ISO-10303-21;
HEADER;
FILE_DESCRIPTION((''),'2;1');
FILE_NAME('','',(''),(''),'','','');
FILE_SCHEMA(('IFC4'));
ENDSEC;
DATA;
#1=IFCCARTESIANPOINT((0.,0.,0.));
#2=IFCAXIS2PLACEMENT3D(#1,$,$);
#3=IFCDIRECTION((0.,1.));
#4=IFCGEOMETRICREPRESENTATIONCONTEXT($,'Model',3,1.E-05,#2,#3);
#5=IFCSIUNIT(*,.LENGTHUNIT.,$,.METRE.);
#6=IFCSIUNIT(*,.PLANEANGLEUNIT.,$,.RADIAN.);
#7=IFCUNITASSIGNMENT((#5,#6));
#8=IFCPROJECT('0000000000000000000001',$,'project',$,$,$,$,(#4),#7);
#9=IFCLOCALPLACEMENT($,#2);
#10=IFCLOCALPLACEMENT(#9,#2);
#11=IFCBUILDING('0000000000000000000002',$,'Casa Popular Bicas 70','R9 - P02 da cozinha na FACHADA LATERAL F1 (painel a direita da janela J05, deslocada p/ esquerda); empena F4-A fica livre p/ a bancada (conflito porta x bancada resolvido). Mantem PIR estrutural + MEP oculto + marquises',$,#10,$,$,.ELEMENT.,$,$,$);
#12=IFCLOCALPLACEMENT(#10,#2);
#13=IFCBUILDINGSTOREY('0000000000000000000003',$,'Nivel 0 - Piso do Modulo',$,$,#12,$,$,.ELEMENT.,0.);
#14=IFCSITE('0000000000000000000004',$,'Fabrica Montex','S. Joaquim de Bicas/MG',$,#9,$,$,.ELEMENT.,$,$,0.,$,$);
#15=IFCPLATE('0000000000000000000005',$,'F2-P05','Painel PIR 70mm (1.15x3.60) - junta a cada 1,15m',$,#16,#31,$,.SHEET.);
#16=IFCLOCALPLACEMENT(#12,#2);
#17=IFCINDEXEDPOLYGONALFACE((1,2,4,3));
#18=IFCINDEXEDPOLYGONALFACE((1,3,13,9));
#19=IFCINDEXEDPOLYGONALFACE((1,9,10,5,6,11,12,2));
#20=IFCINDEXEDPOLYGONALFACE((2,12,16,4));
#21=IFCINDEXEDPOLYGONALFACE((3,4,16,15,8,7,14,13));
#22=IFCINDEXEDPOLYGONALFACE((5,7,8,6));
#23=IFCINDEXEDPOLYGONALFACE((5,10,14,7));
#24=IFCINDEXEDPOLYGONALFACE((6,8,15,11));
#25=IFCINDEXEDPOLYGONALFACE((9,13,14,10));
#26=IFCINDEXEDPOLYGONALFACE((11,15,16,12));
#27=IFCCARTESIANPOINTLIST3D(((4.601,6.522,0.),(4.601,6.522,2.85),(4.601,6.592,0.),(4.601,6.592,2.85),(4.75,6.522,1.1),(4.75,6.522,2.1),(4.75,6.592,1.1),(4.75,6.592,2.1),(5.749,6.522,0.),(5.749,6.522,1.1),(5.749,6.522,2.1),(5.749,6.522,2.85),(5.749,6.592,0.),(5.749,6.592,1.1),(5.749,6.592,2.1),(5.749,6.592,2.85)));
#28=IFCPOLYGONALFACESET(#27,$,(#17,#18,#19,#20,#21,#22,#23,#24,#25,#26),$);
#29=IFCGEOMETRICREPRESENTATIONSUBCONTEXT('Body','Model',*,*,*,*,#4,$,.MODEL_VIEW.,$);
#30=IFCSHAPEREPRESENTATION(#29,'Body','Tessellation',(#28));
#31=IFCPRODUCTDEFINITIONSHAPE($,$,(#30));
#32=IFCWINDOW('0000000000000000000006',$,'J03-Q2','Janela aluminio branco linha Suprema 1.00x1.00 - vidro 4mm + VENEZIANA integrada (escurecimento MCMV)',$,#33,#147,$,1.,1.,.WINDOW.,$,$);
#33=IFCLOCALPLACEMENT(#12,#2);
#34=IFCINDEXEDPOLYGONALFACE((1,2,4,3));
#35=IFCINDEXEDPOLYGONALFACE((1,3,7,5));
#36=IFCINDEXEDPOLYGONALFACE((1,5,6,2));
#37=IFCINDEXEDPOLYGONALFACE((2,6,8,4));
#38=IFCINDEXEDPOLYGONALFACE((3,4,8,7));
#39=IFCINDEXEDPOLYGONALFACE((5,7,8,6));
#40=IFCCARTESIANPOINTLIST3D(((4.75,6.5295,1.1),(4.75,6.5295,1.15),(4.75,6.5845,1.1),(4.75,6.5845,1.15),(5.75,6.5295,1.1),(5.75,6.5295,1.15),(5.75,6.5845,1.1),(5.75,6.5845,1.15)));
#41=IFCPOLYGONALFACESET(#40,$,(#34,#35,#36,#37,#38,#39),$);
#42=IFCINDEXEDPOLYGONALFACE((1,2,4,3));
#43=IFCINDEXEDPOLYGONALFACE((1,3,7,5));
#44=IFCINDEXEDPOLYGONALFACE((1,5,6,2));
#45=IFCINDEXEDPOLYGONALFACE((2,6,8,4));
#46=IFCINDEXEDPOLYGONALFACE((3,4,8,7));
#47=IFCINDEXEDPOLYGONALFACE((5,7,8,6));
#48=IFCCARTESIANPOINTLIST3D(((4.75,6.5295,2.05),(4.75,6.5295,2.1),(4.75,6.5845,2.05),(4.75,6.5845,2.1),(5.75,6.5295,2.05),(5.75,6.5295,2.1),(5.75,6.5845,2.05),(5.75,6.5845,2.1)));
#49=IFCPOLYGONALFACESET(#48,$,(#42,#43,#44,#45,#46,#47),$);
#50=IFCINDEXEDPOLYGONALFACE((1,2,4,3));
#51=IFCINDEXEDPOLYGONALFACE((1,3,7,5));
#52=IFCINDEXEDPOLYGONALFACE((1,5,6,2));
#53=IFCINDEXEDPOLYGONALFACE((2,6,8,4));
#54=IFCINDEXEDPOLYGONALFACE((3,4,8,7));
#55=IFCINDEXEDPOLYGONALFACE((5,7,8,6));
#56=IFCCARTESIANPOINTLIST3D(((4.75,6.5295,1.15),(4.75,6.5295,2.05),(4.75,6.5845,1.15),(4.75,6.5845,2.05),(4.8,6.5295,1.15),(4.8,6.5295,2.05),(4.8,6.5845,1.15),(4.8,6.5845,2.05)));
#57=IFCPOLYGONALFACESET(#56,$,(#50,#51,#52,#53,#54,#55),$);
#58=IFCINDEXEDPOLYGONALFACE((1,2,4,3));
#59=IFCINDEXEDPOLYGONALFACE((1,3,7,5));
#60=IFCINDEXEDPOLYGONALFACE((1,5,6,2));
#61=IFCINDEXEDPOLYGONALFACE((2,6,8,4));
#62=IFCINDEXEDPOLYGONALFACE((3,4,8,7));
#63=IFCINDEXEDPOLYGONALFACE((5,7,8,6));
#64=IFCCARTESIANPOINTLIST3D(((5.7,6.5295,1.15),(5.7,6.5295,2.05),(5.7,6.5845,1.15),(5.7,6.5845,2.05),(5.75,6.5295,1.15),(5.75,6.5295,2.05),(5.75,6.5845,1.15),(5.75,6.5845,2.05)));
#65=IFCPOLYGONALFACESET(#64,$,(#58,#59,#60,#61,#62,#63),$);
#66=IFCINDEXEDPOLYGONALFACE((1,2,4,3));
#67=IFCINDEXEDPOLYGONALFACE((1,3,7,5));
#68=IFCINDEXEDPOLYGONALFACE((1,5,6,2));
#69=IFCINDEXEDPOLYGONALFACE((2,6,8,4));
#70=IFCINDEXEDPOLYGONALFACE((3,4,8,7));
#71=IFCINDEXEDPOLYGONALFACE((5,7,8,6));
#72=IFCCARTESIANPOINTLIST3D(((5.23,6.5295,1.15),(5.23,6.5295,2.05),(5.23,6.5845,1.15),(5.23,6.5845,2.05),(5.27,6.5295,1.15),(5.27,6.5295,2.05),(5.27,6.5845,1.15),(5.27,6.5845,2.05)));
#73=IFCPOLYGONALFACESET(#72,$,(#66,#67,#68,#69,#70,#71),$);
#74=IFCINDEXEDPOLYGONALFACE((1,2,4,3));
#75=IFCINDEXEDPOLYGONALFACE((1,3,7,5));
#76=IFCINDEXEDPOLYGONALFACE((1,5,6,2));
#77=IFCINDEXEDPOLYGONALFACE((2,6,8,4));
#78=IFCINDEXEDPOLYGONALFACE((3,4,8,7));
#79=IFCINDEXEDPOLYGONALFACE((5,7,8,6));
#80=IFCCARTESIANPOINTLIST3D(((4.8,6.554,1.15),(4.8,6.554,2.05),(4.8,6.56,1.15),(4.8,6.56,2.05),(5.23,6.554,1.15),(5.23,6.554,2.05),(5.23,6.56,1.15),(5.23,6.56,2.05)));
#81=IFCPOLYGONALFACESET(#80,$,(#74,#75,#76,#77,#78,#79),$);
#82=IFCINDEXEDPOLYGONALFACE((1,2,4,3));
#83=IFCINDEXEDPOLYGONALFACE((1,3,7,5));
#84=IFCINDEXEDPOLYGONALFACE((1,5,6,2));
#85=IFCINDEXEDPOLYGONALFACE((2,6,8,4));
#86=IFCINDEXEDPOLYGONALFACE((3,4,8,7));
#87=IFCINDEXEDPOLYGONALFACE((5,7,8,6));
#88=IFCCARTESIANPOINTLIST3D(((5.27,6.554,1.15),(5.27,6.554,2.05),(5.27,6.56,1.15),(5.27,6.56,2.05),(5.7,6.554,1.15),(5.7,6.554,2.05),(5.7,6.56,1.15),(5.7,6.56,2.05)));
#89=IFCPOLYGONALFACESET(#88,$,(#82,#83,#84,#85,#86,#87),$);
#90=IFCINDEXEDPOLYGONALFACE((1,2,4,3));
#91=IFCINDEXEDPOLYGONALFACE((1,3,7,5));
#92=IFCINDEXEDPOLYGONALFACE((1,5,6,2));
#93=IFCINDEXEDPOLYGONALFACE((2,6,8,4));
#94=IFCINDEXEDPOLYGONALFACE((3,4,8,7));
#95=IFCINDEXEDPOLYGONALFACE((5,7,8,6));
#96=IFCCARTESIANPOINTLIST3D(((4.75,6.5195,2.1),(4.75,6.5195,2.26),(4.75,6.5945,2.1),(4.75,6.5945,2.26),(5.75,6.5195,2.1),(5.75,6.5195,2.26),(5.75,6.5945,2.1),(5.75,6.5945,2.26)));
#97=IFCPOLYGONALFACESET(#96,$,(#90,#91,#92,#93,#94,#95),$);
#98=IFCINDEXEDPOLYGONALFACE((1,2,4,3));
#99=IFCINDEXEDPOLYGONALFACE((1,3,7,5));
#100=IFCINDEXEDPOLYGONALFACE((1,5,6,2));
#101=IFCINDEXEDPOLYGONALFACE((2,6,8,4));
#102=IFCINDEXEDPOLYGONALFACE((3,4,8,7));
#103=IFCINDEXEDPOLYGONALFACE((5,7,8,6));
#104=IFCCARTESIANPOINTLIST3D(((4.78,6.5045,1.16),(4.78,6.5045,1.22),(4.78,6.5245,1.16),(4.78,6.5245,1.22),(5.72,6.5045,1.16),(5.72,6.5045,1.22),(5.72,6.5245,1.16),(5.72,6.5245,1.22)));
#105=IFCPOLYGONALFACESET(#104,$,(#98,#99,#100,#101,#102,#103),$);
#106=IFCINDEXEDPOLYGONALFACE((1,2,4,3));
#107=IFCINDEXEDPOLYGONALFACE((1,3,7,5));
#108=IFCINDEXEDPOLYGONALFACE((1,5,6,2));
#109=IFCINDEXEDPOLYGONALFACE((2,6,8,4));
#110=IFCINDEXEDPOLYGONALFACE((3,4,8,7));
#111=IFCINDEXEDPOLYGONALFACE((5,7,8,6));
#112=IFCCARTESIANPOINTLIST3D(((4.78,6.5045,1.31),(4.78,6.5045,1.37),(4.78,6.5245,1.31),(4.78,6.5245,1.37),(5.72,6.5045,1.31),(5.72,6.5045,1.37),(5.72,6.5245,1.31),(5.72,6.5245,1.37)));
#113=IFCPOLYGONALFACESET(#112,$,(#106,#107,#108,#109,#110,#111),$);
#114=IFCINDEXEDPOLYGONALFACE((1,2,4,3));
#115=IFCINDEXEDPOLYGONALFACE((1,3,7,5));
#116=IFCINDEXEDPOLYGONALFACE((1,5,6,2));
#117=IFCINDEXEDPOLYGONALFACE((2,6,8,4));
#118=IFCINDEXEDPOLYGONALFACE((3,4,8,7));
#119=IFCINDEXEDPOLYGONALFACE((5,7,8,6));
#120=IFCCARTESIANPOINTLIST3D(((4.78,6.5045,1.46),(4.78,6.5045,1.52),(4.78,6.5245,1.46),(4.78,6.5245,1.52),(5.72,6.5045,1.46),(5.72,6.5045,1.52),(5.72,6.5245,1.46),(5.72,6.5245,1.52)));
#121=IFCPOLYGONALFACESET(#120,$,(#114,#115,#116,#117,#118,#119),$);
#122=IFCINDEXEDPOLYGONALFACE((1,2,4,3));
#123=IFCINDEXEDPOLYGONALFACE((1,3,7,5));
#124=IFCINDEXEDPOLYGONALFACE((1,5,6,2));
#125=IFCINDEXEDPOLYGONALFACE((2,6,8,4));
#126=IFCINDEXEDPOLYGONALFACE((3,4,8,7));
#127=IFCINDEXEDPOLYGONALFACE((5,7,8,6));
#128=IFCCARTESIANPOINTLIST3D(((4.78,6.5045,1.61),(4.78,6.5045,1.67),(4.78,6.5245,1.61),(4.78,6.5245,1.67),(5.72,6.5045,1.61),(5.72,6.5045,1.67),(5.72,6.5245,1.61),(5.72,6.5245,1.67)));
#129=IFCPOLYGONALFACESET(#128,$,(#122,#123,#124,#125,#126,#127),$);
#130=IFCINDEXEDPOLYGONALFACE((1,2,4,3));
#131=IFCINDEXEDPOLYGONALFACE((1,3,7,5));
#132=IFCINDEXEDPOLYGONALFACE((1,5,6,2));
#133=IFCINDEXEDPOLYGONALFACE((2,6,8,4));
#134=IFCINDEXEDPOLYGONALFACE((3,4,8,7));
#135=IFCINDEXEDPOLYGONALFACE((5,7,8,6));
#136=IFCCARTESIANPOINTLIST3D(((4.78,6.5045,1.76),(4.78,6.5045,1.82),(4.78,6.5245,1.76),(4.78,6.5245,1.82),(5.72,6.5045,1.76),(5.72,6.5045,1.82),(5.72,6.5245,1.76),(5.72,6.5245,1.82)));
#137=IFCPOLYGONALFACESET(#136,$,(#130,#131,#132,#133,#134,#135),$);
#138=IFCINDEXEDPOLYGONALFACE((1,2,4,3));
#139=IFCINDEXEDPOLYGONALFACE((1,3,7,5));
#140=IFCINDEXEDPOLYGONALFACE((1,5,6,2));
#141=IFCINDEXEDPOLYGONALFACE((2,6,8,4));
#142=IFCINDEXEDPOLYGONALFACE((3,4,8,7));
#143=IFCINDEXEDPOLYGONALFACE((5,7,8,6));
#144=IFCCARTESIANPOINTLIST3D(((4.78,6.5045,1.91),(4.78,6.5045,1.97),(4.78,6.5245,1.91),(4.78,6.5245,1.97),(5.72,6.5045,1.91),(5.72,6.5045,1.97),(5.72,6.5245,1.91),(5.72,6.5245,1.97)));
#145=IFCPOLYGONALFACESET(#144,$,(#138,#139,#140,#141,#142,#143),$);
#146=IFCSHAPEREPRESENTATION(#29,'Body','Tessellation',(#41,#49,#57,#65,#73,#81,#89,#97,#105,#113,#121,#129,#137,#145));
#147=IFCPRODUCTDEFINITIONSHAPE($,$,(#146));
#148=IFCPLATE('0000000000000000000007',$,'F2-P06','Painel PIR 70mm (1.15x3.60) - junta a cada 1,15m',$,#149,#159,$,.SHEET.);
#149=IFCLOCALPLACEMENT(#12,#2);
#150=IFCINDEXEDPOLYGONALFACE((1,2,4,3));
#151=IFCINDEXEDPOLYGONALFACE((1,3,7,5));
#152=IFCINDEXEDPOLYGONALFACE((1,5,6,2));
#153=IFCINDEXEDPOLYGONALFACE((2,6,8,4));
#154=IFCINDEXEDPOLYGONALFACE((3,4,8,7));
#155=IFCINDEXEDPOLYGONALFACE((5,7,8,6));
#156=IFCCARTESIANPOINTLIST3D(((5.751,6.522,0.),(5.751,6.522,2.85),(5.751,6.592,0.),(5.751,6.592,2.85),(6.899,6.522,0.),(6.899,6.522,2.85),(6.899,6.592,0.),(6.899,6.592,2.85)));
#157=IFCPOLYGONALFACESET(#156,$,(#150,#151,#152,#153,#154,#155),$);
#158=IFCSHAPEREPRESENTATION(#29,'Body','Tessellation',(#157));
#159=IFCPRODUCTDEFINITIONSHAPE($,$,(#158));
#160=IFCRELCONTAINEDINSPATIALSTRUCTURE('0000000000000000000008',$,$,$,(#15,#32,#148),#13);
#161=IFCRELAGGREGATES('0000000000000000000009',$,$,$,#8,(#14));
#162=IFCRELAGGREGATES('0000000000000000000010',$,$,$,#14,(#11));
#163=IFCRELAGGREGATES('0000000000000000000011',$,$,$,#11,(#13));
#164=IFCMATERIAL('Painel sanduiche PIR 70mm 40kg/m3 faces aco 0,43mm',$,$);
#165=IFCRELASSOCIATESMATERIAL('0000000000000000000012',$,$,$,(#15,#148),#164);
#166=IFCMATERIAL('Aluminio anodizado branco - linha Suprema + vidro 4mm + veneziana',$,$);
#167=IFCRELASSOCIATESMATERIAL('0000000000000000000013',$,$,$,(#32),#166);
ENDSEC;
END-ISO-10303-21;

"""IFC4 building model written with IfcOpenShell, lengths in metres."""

from ifc_helpers import new_model, si_unit, direction, frame, frame_2d, origin, origin_2d, place, context, subcontext, project, spatial, rectangle, extrude, material, element, fill, save


model = new_model("IFC4")

# Units and contexts
model_context_1 = context("Model", 3, precision=1e-05, world=origin(), true_north=direction((0.0, 1.0)))
body_context_1 = subcontext(model_context_1, "Body", "Model", "MODEL_VIEW")
ifc_project = project(units=[si_unit("LENGTHUNIT", "METRE"), si_unit("PLANEANGLEUNIT", "RADIAN")], contexts=[model_context_1])

# Site, building, storey
site_placement = place(None, origin())
site = spatial("IfcSite", under=ifc_project, at=site_placement, Name="Fabrica Montex", Description="S. Joaquim de Bicas/MG", CompositionType="ELEMENT", RefElevation=0.0)
building_placement = place(site_placement, origin())
building = spatial("IfcBuilding", under=site, at=building_placement, Name="Casa Popular Bicas 70", Description="R9 - P02 da cozinha na FACHADA LATERAL F1 (painel a direita da janela J05, deslocada p/ esquerda); empena F4-A fica livre p/ a bancada (conflito porta x bancada resolvido). Mantem PIR estrutural + MEP oculto + marquises", CompositionType="ELEMENT")
storey_placement = place(building_placement, origin())
storey = spatial("IfcBuildingStorey", under=building, at=storey_placement, Name="Nivel 0 - Piso do Modulo", CompositionType="ELEMENT", Elevation=0.0)

# Plate, opening, window
ifc_material_1 = material(Name="Painel sanduiche PIR 70mm 40kg/m3 faces aco 0,43mm")
plate_1_placement = place(storey_placement, frame((4.601, 6.557, 0.0), x_axis=(1.0, 0.0, 0.0)))
plate_1 = element("IfcPlate", 1, at=plate_1_placement, inside=storey, material=ifc_material_1, Name="F2-P05", Description="Painel PIR 70mm (1.15x3.60) - junta a cada 1,15m", PredefinedType="SHEET", context=body_context_1, shape_type="SweptSolid", body=[
    extrude(rectangle(XDim=1.148, YDim=0.07, at=frame_2d((0.574, 0.0))), origin(), (0.0, 0.0, 1.0), 2.85),
])
opening_1_placement = place(storey_placement, frame((5.25, 6.557, 1.1)))
opening_1 = element("IfcOpeningElement", 2, at=opening_1_placement, cuts=plate_1, PredefinedType="OPENING", context=body_context_1, shape_type="SweptSolid", body=[
    extrude(rectangle(XDim=1.0, YDim=0.1, at=origin_2d()), origin(), (0.0, 0.0, 1.0), 1.0),
])
ifc_material_2 = material(Name="Aluminio anodizado branco - linha Suprema + vidro 4mm + veneziana")
window_placement = place(storey_placement, frame((4.75, 6.557, 1.1), x_axis=(1.0, 0.0, 0.0)))
window = element("IfcWindow", 3, at=window_placement, inside=storey, material=ifc_material_2, Name="J03-Q2", Description="Janela aluminio branco linha Suprema 1.00x1.00 - vidro 4mm + VENEZIANA integrada (escurecimento MCMV)", OverallHeight=1.0, OverallWidth=1.0, PredefinedType="WINDOW", context=body_context_1, shape_type="SweptSolid", body=[
    extrude(rectangle(XDim=1.0, YDim=0.055, at=frame_2d((0.5, 0.0))), origin(), (0.0, 0.0, 1.0), 0.05),
    extrude(rectangle(XDim=1.0, YDim=0.055, at=frame_2d((0.5, 0.0))), frame((0.0, 0.0, 0.95)), (0.0, 0.0, 1.0), 0.05),
    extrude(rectangle(XDim=0.05, YDim=0.055, at=frame_2d((0.025, 0.0))), frame((0.0, 0.0, 0.05)), (0.0, 0.0, 1.0), 0.9),
    extrude(rectangle(XDim=0.05, YDim=0.055, at=frame_2d((0.975, 0.0))), frame((0.0, 0.0, 0.05)), (0.0, 0.0, 1.0), 0.9),
    extrude(rectangle(XDim=0.04, YDim=0.055, at=frame_2d((0.5, 0.0))), frame((0.0, 0.0, 0.05)), (0.0, 0.0, 1.0), 0.9),
    extrude(rectangle(XDim=0.43, YDim=0.006, at=frame_2d((0.265, 0.0))), frame((0.0, 0.0, 0.05)), (0.0, 0.0, 1.0), 0.9),
    extrude(rectangle(XDim=0.43, YDim=0.006, at=frame_2d((0.735, 0.0))), frame((0.0, 0.0, 0.05)), (0.0, 0.0, 1.0), 0.9),
    extrude(rectangle(XDim=1.0, YDim=0.075, at=frame_2d((0.5, 0.0))), frame((0.0, 0.0, 1.0)), (0.0, 0.0, 1.0), 0.16),
    extrude(rectangle(XDim=0.94, YDim=0.02, at=frame_2d((0.5, -0.0425))), frame((0.0, 0.0, 0.06)), (0.0, 0.0, 1.0), 0.06),
    extrude(rectangle(XDim=0.94, YDim=0.02, at=frame_2d((0.5, -0.0425))), frame((0.0, 0.0, 0.21)), (0.0, 0.0, 1.0), 0.06),
    extrude(rectangle(XDim=0.94, YDim=0.02, at=frame_2d((0.5, -0.0425))), frame((0.0, 0.0, 0.36)), (0.0, 0.0, 1.0), 0.06),
    extrude(rectangle(XDim=0.94, YDim=0.02, at=frame_2d((0.5, -0.0425))), frame((0.0, 0.0, 0.51)), (0.0, 0.0, 1.0), 0.06),
    extrude(rectangle(XDim=0.94, YDim=0.02, at=frame_2d((0.5, -0.0425))), frame((0.0, 0.0, 0.66)), (0.0, 0.0, 1.0), 0.06),
    extrude(rectangle(XDim=0.94, YDim=0.02, at=frame_2d((0.5, -0.0425))), frame((0.0, 0.0, 0.81)), (0.0, 0.0, 1.0), 0.06),
])
fill(opening_1, window)

# Plate
plate_2_placement = place(storey_placement, frame((5.751, 6.557, 0.0), x_axis=(1.0, 0.0, 0.0)))
element("IfcPlate", 4, at=plate_2_placement, inside=storey, material=ifc_material_1, Name="F2-P06", Description="Painel PIR 70mm (1.15x3.60) - junta a cada 1,15m", PredefinedType="SHEET", context=body_context_1, shape_type="SweptSolid", body=[
    extrude(rectangle(XDim=1.148, YDim=0.07, at=frame_2d((0.574, 0.0))), origin(), (0.0, 0.0, 1.0), 2.85),
])

save(model, "model.ifc")
